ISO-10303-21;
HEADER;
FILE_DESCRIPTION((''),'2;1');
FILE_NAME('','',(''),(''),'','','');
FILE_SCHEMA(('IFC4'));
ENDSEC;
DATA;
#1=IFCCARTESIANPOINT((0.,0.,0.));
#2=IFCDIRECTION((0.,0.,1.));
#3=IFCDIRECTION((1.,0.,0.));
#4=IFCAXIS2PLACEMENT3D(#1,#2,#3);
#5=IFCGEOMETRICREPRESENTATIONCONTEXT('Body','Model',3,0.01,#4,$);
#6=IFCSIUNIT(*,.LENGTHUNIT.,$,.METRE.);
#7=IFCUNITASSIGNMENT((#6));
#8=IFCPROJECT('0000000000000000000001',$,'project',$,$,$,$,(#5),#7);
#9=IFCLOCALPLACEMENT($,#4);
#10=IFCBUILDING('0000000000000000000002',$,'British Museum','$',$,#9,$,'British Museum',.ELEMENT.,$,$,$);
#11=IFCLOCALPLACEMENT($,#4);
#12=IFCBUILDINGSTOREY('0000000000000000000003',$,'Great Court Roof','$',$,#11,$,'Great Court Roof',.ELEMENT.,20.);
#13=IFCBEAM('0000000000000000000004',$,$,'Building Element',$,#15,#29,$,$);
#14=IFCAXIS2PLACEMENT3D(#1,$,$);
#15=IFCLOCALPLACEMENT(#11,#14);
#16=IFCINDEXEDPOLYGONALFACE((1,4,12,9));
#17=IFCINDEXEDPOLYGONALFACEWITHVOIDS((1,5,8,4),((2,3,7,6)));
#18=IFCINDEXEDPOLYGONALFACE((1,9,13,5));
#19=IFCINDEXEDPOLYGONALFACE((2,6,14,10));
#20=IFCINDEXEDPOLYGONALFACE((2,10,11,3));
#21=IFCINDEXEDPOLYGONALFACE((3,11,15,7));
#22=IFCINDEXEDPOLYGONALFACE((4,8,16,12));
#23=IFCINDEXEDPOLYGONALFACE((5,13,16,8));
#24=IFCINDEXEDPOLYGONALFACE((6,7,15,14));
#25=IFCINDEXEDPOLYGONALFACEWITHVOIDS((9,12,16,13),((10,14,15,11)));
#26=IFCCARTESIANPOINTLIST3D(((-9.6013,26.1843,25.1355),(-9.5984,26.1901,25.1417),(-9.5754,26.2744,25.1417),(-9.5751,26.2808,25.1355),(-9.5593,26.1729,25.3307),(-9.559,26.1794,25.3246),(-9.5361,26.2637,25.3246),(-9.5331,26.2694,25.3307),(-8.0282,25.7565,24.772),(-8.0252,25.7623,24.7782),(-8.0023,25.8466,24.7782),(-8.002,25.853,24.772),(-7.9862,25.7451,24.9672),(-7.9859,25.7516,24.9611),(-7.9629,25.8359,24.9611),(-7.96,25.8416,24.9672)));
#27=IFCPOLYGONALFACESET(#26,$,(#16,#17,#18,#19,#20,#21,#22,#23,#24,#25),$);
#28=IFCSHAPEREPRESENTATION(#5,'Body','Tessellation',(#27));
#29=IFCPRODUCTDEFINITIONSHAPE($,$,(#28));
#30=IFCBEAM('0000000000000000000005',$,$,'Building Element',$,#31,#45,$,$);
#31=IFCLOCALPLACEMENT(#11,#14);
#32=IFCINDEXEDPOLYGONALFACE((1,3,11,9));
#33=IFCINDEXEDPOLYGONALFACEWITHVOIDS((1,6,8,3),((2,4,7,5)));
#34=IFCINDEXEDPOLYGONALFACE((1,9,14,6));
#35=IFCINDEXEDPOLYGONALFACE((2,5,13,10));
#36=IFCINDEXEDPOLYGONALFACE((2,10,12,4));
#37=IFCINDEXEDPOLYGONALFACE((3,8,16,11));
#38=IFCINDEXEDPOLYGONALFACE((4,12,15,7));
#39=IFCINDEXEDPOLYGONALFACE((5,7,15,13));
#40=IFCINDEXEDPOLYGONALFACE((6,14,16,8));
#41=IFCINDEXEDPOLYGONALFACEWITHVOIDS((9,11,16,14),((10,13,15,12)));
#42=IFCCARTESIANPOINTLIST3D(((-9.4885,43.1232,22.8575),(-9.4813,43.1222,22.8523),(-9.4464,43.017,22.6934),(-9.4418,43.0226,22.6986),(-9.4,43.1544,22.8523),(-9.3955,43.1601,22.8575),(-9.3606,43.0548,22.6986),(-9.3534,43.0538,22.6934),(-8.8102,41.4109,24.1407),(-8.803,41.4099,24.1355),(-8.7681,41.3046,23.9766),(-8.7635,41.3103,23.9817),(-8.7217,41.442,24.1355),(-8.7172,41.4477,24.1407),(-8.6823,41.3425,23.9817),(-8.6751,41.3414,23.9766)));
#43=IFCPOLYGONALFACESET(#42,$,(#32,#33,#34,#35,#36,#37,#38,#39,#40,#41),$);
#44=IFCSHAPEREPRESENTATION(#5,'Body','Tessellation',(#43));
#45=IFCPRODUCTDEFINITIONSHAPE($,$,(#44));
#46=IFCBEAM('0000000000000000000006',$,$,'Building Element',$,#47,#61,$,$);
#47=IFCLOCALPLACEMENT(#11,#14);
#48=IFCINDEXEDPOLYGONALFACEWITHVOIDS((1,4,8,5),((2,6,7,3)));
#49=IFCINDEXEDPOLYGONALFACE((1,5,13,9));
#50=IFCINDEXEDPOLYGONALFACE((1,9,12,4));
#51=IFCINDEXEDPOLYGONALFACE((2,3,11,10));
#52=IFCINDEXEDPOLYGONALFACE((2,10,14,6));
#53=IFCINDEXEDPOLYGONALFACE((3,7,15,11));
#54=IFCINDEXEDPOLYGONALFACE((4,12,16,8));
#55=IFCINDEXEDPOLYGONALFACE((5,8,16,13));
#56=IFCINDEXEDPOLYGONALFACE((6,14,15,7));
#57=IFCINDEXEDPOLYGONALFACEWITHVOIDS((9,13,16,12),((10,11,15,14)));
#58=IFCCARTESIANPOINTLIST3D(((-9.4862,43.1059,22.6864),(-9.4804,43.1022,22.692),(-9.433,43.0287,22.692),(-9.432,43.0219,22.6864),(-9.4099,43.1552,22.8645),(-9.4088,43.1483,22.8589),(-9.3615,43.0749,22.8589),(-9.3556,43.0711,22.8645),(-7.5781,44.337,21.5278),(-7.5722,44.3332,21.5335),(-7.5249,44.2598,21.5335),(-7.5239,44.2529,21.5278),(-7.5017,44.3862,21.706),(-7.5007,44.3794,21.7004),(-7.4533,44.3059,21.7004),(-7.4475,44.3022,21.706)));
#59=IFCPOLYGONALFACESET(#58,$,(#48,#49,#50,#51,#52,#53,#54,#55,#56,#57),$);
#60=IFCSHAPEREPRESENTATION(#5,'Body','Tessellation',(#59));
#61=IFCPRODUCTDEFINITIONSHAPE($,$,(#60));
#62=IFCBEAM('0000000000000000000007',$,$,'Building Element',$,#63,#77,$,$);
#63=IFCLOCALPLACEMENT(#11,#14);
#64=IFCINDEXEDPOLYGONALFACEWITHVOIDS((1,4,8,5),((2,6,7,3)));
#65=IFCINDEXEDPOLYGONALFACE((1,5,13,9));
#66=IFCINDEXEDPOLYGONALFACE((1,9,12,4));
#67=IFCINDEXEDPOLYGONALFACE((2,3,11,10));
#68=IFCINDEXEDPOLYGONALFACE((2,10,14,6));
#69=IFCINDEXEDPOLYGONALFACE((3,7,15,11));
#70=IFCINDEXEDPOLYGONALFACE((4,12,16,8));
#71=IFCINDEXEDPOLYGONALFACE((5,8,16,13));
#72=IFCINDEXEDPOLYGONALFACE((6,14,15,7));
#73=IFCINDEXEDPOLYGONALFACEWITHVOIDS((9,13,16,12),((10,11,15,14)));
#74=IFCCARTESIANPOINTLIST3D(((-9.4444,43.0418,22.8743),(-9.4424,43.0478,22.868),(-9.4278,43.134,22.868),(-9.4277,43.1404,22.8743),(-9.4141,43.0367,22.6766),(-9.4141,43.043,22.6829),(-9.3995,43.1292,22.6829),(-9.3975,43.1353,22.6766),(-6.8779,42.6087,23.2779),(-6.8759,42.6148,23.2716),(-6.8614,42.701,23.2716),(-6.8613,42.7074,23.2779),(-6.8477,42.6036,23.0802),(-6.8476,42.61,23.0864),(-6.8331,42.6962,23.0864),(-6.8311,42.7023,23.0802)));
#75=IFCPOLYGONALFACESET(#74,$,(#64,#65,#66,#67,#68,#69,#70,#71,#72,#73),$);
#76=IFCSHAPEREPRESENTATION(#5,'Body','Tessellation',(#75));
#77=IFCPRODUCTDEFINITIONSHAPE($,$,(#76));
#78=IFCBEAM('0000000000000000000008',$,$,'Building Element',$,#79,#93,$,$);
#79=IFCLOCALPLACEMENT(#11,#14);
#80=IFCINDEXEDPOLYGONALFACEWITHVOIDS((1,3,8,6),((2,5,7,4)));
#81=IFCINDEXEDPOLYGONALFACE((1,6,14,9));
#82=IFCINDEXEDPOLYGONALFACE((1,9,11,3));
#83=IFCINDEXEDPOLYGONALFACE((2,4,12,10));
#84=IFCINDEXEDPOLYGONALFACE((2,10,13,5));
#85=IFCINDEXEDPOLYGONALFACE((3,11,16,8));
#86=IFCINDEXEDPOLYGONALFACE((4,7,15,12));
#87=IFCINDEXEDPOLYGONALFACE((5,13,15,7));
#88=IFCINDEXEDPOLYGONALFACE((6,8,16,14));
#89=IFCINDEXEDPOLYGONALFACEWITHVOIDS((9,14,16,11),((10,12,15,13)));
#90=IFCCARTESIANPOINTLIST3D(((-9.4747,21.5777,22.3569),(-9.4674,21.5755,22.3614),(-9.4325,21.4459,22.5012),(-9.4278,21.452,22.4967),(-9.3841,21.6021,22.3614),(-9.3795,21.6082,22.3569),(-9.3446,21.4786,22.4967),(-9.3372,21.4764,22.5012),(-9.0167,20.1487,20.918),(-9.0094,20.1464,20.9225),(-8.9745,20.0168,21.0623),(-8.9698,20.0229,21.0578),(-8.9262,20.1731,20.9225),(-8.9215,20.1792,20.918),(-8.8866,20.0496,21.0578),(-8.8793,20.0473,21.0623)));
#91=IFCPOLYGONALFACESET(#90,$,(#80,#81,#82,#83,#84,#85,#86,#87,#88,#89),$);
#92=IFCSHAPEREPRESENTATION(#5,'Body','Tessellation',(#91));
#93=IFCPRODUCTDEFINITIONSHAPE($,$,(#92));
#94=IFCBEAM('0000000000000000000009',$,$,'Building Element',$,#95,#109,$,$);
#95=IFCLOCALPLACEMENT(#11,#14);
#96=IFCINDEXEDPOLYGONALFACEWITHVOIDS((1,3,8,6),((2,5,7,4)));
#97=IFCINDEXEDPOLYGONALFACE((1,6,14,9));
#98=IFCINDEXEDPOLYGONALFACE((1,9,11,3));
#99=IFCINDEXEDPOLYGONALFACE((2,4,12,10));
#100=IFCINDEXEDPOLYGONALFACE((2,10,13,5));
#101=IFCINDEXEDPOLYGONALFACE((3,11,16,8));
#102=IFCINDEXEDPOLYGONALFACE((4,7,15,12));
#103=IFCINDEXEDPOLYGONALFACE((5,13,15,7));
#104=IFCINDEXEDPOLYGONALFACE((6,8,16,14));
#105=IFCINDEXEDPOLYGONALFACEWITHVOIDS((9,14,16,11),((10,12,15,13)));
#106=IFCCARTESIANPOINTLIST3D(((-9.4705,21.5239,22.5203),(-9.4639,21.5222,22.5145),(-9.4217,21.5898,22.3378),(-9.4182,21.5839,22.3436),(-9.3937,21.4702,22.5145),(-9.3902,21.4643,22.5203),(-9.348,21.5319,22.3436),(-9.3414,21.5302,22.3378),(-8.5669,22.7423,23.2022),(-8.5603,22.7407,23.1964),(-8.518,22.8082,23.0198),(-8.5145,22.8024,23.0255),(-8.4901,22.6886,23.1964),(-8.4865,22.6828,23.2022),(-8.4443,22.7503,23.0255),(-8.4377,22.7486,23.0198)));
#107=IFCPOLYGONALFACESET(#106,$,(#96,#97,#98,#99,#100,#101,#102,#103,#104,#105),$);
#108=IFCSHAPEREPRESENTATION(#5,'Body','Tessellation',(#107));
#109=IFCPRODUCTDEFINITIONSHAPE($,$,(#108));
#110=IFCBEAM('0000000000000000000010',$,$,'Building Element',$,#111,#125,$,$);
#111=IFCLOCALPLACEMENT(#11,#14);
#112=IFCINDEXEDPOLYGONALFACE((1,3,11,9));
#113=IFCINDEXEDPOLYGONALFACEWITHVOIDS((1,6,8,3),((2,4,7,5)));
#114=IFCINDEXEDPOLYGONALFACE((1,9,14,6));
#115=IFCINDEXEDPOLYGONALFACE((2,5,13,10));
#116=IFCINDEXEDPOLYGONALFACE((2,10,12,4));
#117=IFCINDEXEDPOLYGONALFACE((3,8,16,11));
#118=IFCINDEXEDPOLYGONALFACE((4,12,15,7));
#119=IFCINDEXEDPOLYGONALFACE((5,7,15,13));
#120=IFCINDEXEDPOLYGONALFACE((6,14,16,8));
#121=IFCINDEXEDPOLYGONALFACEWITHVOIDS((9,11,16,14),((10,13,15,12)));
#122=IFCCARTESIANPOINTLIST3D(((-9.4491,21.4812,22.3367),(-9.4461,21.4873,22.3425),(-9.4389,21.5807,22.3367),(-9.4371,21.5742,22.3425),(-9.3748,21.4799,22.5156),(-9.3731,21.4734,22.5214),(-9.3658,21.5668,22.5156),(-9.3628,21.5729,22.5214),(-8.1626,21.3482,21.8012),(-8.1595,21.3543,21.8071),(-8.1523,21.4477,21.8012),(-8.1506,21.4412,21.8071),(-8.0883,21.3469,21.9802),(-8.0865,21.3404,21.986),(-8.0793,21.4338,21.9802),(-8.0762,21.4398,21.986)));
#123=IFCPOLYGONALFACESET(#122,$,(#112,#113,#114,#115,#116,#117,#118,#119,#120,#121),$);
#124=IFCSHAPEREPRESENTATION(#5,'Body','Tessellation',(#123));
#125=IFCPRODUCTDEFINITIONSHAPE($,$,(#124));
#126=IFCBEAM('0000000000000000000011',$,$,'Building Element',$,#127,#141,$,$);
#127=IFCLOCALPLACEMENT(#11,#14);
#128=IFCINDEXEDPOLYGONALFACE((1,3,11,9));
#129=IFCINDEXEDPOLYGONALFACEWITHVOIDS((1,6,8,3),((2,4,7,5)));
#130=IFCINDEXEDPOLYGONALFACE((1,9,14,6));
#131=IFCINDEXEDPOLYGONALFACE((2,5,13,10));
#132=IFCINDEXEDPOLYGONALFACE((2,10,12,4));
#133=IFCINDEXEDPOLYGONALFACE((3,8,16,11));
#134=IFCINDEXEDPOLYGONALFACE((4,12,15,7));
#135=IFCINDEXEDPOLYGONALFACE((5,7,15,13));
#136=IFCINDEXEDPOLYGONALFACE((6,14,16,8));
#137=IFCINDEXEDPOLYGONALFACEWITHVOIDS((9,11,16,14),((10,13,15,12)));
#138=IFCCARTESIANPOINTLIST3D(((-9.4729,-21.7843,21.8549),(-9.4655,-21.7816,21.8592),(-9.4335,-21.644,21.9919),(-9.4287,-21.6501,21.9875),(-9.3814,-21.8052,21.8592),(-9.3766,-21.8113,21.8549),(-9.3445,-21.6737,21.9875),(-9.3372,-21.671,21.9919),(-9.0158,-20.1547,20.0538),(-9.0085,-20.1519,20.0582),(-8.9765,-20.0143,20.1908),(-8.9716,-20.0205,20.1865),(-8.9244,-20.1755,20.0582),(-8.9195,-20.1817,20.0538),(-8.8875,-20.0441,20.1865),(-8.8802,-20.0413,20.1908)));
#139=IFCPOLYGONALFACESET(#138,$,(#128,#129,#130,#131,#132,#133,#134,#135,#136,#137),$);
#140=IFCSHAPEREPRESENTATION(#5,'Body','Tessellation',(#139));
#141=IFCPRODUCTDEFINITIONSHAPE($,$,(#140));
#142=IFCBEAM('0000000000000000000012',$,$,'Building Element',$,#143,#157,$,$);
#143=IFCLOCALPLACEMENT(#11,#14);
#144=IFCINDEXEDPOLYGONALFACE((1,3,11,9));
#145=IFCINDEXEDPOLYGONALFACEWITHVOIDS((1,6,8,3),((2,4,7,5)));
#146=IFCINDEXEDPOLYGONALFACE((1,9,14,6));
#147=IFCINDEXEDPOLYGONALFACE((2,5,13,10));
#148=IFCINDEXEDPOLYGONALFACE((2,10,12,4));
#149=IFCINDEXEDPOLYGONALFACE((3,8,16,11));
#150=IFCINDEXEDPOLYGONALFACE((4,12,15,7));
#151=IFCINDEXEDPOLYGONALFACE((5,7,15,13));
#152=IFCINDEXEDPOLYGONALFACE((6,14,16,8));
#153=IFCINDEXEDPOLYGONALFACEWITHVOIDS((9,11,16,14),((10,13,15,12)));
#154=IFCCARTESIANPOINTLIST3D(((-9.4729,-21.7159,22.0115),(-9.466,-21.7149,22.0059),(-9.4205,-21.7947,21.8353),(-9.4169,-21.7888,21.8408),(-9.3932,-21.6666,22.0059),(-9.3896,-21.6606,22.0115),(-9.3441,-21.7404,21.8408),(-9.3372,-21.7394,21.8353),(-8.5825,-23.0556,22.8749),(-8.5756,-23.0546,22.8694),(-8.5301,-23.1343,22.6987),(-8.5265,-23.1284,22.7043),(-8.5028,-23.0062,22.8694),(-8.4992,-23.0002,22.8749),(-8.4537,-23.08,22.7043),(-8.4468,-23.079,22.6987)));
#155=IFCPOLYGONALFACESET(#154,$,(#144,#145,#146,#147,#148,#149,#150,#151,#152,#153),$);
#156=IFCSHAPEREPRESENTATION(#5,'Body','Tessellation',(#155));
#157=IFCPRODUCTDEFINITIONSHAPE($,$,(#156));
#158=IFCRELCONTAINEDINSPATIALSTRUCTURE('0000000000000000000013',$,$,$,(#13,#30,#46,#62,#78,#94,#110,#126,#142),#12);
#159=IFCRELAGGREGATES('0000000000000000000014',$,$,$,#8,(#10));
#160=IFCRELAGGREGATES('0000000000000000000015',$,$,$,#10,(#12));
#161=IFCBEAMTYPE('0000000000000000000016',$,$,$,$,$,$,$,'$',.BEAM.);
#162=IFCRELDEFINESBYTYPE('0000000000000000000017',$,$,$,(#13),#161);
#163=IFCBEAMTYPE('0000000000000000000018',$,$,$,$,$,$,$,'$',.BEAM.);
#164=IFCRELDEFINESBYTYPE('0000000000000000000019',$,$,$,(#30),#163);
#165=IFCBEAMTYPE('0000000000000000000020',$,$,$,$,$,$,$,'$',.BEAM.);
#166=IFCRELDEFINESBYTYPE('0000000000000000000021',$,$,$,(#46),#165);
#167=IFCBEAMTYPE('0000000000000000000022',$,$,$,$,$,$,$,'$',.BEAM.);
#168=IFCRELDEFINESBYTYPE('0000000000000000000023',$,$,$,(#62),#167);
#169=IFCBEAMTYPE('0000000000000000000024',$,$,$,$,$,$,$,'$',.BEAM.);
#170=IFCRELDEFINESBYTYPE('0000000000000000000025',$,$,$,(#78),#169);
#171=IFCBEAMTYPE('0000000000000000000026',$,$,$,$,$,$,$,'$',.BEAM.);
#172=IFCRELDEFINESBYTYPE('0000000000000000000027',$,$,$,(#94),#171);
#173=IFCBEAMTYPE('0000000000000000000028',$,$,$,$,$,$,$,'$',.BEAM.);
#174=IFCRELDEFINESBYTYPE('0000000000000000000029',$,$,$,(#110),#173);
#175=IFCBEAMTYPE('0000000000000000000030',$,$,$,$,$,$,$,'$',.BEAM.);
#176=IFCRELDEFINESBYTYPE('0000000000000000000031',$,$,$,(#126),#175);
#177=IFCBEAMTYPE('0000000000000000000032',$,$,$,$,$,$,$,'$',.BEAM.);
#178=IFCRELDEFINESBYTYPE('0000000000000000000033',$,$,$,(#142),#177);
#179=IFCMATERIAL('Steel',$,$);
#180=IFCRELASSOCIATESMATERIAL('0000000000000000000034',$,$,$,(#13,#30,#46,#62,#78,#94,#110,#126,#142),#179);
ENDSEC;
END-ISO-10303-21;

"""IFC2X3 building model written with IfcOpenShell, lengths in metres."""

from ifc_helpers import new_model, si_unit, frame, origin_with_axes, origin_2d, place, context, project, spatial, hollow_rectangle, extrude, material, type_object, element, save


model = new_model("IFC2X3")

# Units and contexts
model_context = context("Model", 3, precision=0.01, world=origin_with_axes(), identifier="Body")
ifc_project = project(units=[si_unit("LENGTHUNIT", "METRE")], contexts=[model_context])

# Building, storey
building_placement = place(None, origin_with_axes())
building = spatial("IfcBuilding", under=ifc_project, at=building_placement, Name="British Museum", Description="$", LongName="British Museum", CompositionType="ELEMENT")
storey_placement = place(None, origin_with_axes())
storey = spatial("IfcBuildingStorey", under=building, at=storey_placement, Name="Great Court Roof", Description="$", LongName="Great Court Roof", CompositionType="ELEMENT", Elevation=20.0)

# Beams
ifc_material = material(Name="Steel")
beam_type_1 = type_object("IfcBeamType", ElementType="$", PredefinedType="BEAM")
beam_1_placement = place(None, origin_with_axes())
element("IfcBeam", 1, at=beam_1_placement, inside=storey, type_object=beam_type_1, material=ifc_material, Description="Building Element", context=model_context, shape_type="SweptSolid", body=[
    extrude(hollow_rectangle(XDim=0.1, YDim=0.2, WallThickness=0.0063, InnerFilletRadius=-0.0063, OuterFilletRadius=0.0, at=origin_2d()), frame((-9.5672, 26.2269, 25.2331), z_axis=(0.941829, -0.256122, -0.217624), x_axis=(0.262412, 0.964956, 0.0)), (0.0, 0.0, 1.0), 1.6703),
])
beam_type_2 = type_object("IfcBeamType", ElementType="$", PredefinedType="BEAM")
beam_2_placement = place(None, origin_with_axes())
element("IfcBeam", 2, at=beam_2_placement, inside=storey, type_object=beam_type_2, material=ifc_material, Description="Building Element", context=model_context, shape_type="SweptSolid", body=[
    extrude(hollow_rectangle(XDim=0.1, YDim=0.2, WallThickness=0.0063, InnerFilletRadius=-0.0063, OuterFilletRadius=0.0, at=origin_2d()), frame((-9.4209, 43.0885, 22.7754), z_axis=(0.302182, -0.762838, 0.571633), x_axis=(0.929712, 0.368286, 0.0)), (0.0, 0.0, 1.0), 2.2447),
])
beam_type_3 = type_object("IfcBeamType", ElementType="$", PredefinedType="BEAM")
beam_3_placement = place(None, origin_with_axes())
element("IfcBeam", 3, at=beam_3_placement, inside=storey, type_object=beam_type_3, material=ifc_material, Description="Building Element", context=model_context, shape_type="SweptSolid", body=[
    extrude(hollow_rectangle(XDim=0.1, YDim=0.2, WallThickness=0.0063, InnerFilletRadius=-0.0063, OuterFilletRadius=0.0, at=origin_2d()), frame((-9.4209, 43.0885, 22.7754), z_axis=(0.748515, 0.482909, -0.45445), x_axis=(-0.542124, 0.840299, 0.0)), (0.0, 0.0, 1.0), 2.5493),
])
beam_type_4 = type_object("IfcBeamType", ElementType="$", PredefinedType="BEAM")
beam_4_placement = place(None, origin_with_axes())
element("IfcBeam", 4, at=beam_4_placement, inside=storey, type_object=beam_type_4, material=ifc_material, Description="Building Element", context=model_context, shape_type="SweptSolid", body=[
    extrude(hollow_rectangle(XDim=0.1, YDim=0.2, WallThickness=0.0063, InnerFilletRadius=-0.0063, OuterFilletRadius=0.0, at=origin_2d()), frame((-9.4209, 43.0885, 22.7754), z_axis=(0.974417, -0.164406, 0.153236), x_axis=(0.166371, 0.986063, 0.0)), (0.0, 0.0, 1.0), 2.6338),
])
beam_type_5 = type_object("IfcBeamType", ElementType="$", PredefinedType="BEAM")
beam_5_placement = place(None, origin_with_axes())
element("IfcBeam", 5, at=beam_5_placement, inside=storey, type_object=beam_type_5, material=ifc_material, Description="Building Element", context=model_context, shape_type="SweptSolid", body=[
    extrude(hollow_rectangle(XDim=0.1, YDim=0.2, WallThickness=0.0063, InnerFilletRadius=-0.0063, OuterFilletRadius=0.0, at=origin_2d()), frame((-9.406, 21.527, 22.4291), z_axis=(0.220276, -0.687362, -0.692107), x_axis=(0.952295, 0.305178, 0.0)), (0.0, 0.0, 1.0), 2.079),
])
beam_type_6 = type_object("IfcBeamType", ElementType="$", PredefinedType="BEAM")
beam_6_placement = place(None, origin_with_axes())
element("IfcBeam", 6, at=beam_6_placement, inside=storey, type_object=beam_type_6, material=ifc_material, Description="Building Element", context=model_context, shape_type="SweptSolid", body=[
    extrude(hollow_rectangle(XDim=0.1, YDim=0.2, WallThickness=0.0063, InnerFilletRadius=-0.0063, OuterFilletRadius=0.0, at=origin_2d()), frame((-9.406, 21.527, 22.4291), z_axis=(0.543338, 0.732586, 0.410001), x_axis=(-0.8032, 0.59571, 0.0)), (0.0, 0.0, 1.0), 1.6632),
])
beam_type_7 = type_object("IfcBeamType", ElementType="$", PredefinedType="BEAM")
beam_7_placement = place(None, origin_with_axes())
element("IfcBeam", 7, at=beam_7_placement, inside=storey, type_object=beam_type_7, material=ifc_material, Description="Building Element", context=model_context, shape_type="SweptSolid", body=[
    extrude(hollow_rectangle(XDim=0.1, YDim=0.2, WallThickness=0.0063, InnerFilletRadius=-0.0063, OuterFilletRadius=0.0, at=origin_2d()), frame((-9.406, 21.527, 22.4291), z_axis=(0.919063, -0.095015, -0.382485), x_axis=(0.102834, 0.994699, 0.0)), (0.0, 0.0, 1.0), 1.3999),
])
beam_type_8 = type_object("IfcBeamType", ElementType="$", PredefinedType="BEAM")
beam_8_placement = place(None, origin_with_axes())
element("IfcBeam", 8, at=beam_8_placement, inside=storey, type_object=beam_type_8, material=ifc_material, Description="Building Element", context=model_context, shape_type="SweptSolid", body=[
    extrude(hollow_rectangle(XDim=0.1, YDim=0.2, WallThickness=0.0063, InnerFilletRadius=-0.0063, OuterFilletRadius=0.0, at=origin_2d()), frame((-9.405, -21.7277, 21.9234), z_axis=(0.18492, 0.659374, -0.728719), x_axis=(-0.962852, 0.27003, 0.0)), (0.0, 0.0, 1.0), 2.4715),
])
beam_type_9 = type_object("IfcBeamType", ElementType="$", PredefinedType="BEAM")
beam_9_placement = place(None, origin_with_axes())
element("IfcBeam", 9, at=beam_9_placement, inside=storey, type_object=beam_type_9, material=ifc_material, Description="Building Element", context=model_context, shape_type="SweptSolid", body=[
    extrude(hollow_rectangle(XDim=0.1, YDim=0.2, WallThickness=0.0063, InnerFilletRadius=-0.0063, OuterFilletRadius=0.0, at=origin_2d()), frame((-9.405, -21.7277, 21.9234), z_axis=(0.487713, -0.733782, 0.47297), x_axis=(0.832822, 0.55354, 0.0)), (0.0, 0.0, 1.0), 1.8256),
])

save(model, "model.ifc")
